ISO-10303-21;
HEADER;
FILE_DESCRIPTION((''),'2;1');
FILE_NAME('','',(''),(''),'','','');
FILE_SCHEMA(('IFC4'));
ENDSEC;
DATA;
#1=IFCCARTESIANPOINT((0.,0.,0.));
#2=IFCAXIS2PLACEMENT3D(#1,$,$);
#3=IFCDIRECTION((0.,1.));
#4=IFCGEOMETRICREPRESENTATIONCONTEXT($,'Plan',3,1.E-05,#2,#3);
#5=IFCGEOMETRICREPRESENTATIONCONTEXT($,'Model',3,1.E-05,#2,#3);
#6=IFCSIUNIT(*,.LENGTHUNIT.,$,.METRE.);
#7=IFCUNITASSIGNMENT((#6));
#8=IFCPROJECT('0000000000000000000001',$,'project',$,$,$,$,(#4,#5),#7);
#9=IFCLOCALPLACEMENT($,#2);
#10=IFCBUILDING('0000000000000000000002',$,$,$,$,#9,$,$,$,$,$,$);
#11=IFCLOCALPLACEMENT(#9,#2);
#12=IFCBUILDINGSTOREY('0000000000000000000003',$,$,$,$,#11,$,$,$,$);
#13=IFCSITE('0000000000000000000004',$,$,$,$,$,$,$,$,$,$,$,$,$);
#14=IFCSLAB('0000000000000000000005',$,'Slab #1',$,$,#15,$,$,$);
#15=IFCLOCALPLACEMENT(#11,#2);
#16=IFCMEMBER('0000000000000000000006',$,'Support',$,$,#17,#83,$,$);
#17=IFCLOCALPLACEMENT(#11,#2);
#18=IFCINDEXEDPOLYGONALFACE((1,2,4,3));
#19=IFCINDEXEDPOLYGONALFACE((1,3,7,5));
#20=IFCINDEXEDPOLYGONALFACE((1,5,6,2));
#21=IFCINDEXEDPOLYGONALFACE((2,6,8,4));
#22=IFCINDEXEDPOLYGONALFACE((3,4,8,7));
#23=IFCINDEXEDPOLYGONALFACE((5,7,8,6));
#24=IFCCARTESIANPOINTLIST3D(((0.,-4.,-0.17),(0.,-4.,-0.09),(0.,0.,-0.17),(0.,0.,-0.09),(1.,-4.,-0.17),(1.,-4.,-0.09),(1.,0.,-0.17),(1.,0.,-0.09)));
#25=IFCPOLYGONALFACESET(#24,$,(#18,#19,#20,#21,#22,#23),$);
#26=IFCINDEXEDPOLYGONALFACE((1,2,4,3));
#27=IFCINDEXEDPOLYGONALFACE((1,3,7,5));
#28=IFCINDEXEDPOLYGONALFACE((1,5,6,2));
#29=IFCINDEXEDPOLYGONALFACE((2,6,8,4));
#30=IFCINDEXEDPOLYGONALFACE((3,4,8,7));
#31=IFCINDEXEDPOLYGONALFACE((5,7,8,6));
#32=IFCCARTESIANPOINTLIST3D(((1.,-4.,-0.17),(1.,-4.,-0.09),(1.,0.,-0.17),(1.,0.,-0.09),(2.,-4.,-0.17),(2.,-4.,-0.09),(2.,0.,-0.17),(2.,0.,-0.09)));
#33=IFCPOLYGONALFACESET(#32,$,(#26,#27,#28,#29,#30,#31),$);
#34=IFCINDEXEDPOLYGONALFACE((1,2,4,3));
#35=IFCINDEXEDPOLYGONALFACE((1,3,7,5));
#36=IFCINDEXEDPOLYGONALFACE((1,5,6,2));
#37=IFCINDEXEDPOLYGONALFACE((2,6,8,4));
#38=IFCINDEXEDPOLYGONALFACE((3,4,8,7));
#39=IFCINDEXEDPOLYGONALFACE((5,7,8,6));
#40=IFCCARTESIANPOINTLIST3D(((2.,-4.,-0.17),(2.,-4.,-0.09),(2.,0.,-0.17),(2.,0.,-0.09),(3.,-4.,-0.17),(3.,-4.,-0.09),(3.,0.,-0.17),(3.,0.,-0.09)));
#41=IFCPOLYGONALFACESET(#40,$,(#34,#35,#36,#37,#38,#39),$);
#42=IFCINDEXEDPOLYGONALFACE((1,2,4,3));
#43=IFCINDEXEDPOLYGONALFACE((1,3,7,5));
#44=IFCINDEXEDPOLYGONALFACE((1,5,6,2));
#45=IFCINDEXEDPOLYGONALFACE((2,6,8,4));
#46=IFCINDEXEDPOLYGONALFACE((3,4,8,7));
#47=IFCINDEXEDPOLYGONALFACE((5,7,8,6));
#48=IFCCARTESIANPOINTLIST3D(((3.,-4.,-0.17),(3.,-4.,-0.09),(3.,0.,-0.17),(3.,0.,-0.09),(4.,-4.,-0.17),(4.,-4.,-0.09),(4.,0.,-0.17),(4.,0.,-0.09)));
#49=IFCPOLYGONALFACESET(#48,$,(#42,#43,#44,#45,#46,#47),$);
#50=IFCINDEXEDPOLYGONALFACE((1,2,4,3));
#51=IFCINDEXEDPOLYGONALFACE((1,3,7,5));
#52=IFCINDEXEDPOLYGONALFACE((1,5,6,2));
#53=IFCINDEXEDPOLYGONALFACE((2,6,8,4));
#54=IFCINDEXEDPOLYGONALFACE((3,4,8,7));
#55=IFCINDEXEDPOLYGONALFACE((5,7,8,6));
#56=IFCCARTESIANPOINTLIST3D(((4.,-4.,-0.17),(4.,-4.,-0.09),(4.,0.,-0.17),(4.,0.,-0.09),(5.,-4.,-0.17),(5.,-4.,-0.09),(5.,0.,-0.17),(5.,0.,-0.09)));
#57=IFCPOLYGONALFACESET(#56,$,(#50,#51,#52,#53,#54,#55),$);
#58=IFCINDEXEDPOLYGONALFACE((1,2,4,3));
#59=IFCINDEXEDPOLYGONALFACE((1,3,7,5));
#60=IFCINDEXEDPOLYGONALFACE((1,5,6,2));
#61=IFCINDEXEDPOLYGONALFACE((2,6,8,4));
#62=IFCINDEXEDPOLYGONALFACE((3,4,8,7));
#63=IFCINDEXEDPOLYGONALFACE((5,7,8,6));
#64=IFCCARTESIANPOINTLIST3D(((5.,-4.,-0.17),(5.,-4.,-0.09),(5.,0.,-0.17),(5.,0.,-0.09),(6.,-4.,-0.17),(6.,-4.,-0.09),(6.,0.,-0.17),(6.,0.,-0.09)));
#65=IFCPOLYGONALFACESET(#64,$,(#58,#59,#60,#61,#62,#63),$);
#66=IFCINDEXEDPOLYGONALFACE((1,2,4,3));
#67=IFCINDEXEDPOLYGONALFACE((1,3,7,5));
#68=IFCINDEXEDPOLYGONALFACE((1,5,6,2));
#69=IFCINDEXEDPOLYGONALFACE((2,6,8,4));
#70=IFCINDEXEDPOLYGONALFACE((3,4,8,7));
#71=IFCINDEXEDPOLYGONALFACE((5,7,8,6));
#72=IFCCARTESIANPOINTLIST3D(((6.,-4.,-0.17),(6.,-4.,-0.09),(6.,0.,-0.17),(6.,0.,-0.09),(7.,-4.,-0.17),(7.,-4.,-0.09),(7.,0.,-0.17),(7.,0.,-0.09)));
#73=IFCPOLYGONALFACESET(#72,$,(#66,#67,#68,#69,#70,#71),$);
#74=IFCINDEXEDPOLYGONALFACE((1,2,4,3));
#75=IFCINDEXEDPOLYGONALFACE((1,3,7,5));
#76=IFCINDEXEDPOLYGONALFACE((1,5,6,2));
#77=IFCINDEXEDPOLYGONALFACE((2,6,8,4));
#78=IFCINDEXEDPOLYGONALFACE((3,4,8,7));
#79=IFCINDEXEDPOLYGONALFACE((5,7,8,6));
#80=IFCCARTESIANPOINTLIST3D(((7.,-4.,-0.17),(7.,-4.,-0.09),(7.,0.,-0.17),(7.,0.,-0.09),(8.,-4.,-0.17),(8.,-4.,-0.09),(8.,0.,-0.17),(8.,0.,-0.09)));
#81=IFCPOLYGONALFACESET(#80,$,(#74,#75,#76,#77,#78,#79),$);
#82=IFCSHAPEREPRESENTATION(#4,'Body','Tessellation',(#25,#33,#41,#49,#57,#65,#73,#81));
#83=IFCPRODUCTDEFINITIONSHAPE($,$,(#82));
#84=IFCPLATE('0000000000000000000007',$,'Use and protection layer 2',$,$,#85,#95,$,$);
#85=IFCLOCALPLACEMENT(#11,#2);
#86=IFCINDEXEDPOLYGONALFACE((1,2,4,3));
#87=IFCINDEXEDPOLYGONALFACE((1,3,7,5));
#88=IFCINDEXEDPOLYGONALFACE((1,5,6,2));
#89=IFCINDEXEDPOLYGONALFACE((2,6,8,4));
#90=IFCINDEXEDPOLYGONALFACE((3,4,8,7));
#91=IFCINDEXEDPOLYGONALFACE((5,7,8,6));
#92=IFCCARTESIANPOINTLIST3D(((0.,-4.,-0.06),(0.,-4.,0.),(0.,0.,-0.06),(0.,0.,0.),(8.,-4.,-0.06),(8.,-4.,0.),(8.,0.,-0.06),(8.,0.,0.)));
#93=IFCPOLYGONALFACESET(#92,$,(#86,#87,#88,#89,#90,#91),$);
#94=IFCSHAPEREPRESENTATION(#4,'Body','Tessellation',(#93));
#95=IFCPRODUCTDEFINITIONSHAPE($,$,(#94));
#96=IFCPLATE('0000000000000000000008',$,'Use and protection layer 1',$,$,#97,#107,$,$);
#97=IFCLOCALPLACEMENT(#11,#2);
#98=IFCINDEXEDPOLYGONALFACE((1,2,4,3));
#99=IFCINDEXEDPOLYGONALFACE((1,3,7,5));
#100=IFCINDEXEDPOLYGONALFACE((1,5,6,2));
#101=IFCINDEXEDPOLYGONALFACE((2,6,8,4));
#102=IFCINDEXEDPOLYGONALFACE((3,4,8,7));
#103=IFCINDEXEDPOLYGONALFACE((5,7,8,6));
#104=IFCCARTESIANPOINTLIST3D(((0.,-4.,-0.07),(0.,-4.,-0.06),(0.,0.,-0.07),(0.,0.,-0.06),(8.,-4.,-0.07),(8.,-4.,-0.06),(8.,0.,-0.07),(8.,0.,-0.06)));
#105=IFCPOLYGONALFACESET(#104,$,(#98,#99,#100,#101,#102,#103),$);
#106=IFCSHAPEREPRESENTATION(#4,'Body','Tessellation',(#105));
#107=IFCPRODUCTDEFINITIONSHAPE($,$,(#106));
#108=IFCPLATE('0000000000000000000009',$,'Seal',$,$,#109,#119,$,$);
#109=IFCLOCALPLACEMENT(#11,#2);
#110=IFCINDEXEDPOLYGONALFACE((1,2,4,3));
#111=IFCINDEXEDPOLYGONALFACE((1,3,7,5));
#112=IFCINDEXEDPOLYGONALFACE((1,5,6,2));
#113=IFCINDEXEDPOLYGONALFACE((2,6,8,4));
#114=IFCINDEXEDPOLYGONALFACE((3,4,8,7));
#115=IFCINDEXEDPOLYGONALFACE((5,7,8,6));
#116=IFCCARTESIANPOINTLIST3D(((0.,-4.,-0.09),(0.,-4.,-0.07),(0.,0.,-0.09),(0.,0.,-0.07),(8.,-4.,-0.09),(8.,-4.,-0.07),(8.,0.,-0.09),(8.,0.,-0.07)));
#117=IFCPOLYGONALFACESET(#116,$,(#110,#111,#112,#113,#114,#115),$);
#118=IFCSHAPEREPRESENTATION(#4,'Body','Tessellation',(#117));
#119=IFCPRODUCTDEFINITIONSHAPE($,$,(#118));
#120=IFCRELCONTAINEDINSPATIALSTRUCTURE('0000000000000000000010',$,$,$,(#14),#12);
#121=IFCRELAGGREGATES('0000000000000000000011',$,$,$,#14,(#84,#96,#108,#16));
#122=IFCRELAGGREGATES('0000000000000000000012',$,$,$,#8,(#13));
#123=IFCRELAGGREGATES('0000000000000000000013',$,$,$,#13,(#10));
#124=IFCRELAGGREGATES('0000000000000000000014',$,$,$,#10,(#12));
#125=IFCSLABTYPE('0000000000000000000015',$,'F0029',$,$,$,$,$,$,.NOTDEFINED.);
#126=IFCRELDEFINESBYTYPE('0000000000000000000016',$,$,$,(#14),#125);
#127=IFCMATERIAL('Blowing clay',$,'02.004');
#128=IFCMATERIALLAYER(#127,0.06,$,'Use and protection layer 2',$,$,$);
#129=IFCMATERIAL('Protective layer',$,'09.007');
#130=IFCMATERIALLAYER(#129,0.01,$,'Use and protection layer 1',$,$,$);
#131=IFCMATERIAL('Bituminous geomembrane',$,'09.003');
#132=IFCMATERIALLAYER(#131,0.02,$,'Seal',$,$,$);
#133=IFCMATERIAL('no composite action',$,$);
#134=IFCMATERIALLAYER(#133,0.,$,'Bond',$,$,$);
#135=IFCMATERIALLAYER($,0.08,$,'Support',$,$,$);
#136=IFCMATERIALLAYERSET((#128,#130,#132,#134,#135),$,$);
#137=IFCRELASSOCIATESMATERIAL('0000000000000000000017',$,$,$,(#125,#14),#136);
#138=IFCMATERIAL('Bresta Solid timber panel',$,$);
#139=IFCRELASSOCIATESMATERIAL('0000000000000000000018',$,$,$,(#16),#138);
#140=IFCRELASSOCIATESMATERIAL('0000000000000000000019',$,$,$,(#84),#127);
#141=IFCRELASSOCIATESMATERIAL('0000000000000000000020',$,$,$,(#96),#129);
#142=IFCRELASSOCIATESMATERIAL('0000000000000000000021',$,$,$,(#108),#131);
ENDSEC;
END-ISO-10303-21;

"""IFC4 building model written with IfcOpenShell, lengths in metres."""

from ifc_helpers import new_model, si_unit, direction, frame, frame_2d, origin, origin_with_axes, place, context, project, spatial, rectangle, extrude, material, layer, layer_set, type_object, element, aggregate, save


model = new_model("IFC4")

# Units and contexts
plan_context = context("Plan", 3, precision=1e-05, world=origin(), true_north=direction((0.0, 1.0)))
model_context = context("Model", 3, precision=1e-05, world=origin(), true_north=direction((0.0, 1.0)))
ifc_project = project(units=[si_unit("LENGTHUNIT", "METRE")], contexts=[plan_context, model_context])

# Site, building, storey
site = spatial("IfcSite", under=ifc_project)
building_placement = place(None, origin())
building = spatial("IfcBuilding", under=site, at=building_placement)
storey_placement = place(building_placement, origin())
storey = spatial("IfcBuildingStorey", under=building, at=storey_placement)

# Slab, member, plates
ifc_material_1 = material(Name="Blowing clay", Category="02.004")
ifc_layer_1 = layer(ifc_material_1, 0.06, Name="Use and protection layer 2")
ifc_material_2 = material(Name="Protective layer", Category="09.007")
ifc_layer_2 = layer(ifc_material_2, 0.01, Name="Use and protection layer 1")
ifc_material_3 = material(Name="Bituminous geomembrane", Category="09.003")
ifc_layer_3 = layer(ifc_material_3, 0.02, Name="Seal")
ifc_material_4 = material(Name="no composite action")
ifc_layer_4 = layer(ifc_material_4, 0.0, Name="Bond")
ifc_layer_5 = layer(None, 0.08, Name="Support")
ifc_layer_set = layer_set([ifc_layer_1, ifc_layer_2, ifc_layer_3, ifc_layer_4, ifc_layer_5])
slab_type = type_object("IfcSlabType", Name="F0029", PredefinedType="NOTDEFINED", material=ifc_layer_set)
slab_placement = place(None, frame((0.0, 0.0, 0.0), z_axis=(0.0, 0.0, -1.0), x_axis=(1.0, 0.0, 0.0)))
slab = element("IfcSlab", 1, at=slab_placement, inside=storey, type_object=slab_type, material=ifc_layer_set, Name="Slab #1")
ifc_material_5 = material(Name="Bresta Solid timber panel")
member_placement = place(slab_placement, origin())
member = element("IfcMember", 2, at=member_placement, material=ifc_material_5, Name="Support", context=plan_context, shape_type="SweptSolid", body=[
    extrude(rectangle(XDim=1.0, YDim=0.08, at=frame_2d((0.5, 0.04), x_axis=(1.0, 0.0))), frame((0.0, 4.0, 0.09), z_axis=(0.0, -1.0, 0.0), x_axis=(1.0, 0.0, 0.0)), (0.0, 0.0, 1.0), 4.0),
    extrude(rectangle(XDim=1.0, YDim=0.08, at=frame_2d((0.5, 0.04), x_axis=(1.0, 0.0))), frame((1.0, 4.0, 0.09), z_axis=(0.0, -1.0, 0.0), x_axis=(1.0, 0.0, 0.0)), (0.0, 0.0, 1.0), 4.0),
    extrude(rectangle(XDim=1.0, YDim=0.08, at=frame_2d((0.5, 0.04), x_axis=(1.0, 0.0))), frame((2.0, 4.0, 0.09), z_axis=(0.0, -1.0, 0.0), x_axis=(1.0, 0.0, 0.0)), (0.0, 0.0, 1.0), 4.0),
    extrude(rectangle(XDim=1.0, YDim=0.08, at=frame_2d((0.5, 0.04), x_axis=(1.0, 0.0))), frame((3.0, 4.0, 0.09), z_axis=(0.0, -1.0, 0.0), x_axis=(1.0, 0.0, 0.0)), (0.0, 0.0, 1.0), 4.0),
    extrude(rectangle(XDim=1.0, YDim=0.08, at=frame_2d((0.5, 0.04), x_axis=(1.0, 0.0))), frame((4.0, 4.0, 0.09), z_axis=(0.0, -1.0, 0.0), x_axis=(1.0, 0.0, 0.0)), (0.0, 0.0, 1.0), 4.0),
    extrude(rectangle(XDim=1.0, YDim=0.08, at=frame_2d((0.5, 0.04), x_axis=(1.0, 0.0))), frame((5.0, 4.0, 0.09), z_axis=(0.0, -1.0, 0.0), x_axis=(1.0, 0.0, 0.0)), (0.0, 0.0, 1.0), 4.0),
    extrude(rectangle(XDim=1.0, YDim=0.08, at=frame_2d((0.5, 0.04), x_axis=(1.0, 0.0))), frame((6.0, 4.0, 0.09), z_axis=(0.0, -1.0, 0.0), x_axis=(1.0, 0.0, 0.0)), (0.0, 0.0, 1.0), 4.0),
    extrude(rectangle(XDim=1.0, YDim=0.08, at=frame_2d((0.5, 0.04), x_axis=(1.0, 0.0))), frame((7.0, 4.0, 0.09), z_axis=(0.0, -1.0, 0.0), x_axis=(1.0, 0.0, 0.0)), (0.0, 0.0, 1.0), 4.0),
])
plate_1_placement = place(slab_placement, origin())
plate_1 = element("IfcPlate", 3, at=plate_1_placement, material=ifc_material_1, Name="Use and protection layer 2", context=plan_context, shape_type="SweptSolid", body=[
    extrude(rectangle(XDim=8.0, YDim=4.0, at=frame_2d((4.0, 2.0), x_axis=(1.0, 0.0))), origin_with_axes(), (0.0, 0.0, 1.0), 0.06),
])
plate_2_placement = place(slab_placement, origin())
plate_2 = element("IfcPlate", 4, at=plate_2_placement, material=ifc_material_2, Name="Use and protection layer 1", context=plan_context, shape_type="SweptSolid", body=[
    extrude(rectangle(XDim=8.0, YDim=4.0, at=frame_2d((4.0, 2.0), x_axis=(1.0, 0.0))), frame((0.0, 0.0, 0.06), z_axis=(0.0, 0.0, 1.0), x_axis=(1.0, 0.0, 0.0)), (0.0, 0.0, 1.0), 0.01),
])
plate_3_placement = place(slab_placement, origin())
plate_3 = element("IfcPlate", 5, at=plate_3_placement, material=ifc_material_3, Name="Seal", context=plan_context, shape_type="SweptSolid", body=[
    extrude(rectangle(XDim=8.0, YDim=4.0, at=frame_2d((4.0, 2.0), x_axis=(1.0, 0.0))), frame((0.0, 0.0, 0.07), z_axis=(0.0, 0.0, 1.0), x_axis=(1.0, 0.0, 0.0)), (0.0, 0.0, 1.0), 0.02),
])
aggregate(slab, [plate_1, plate_2, plate_3, member])

save(model, "model.ifc")
